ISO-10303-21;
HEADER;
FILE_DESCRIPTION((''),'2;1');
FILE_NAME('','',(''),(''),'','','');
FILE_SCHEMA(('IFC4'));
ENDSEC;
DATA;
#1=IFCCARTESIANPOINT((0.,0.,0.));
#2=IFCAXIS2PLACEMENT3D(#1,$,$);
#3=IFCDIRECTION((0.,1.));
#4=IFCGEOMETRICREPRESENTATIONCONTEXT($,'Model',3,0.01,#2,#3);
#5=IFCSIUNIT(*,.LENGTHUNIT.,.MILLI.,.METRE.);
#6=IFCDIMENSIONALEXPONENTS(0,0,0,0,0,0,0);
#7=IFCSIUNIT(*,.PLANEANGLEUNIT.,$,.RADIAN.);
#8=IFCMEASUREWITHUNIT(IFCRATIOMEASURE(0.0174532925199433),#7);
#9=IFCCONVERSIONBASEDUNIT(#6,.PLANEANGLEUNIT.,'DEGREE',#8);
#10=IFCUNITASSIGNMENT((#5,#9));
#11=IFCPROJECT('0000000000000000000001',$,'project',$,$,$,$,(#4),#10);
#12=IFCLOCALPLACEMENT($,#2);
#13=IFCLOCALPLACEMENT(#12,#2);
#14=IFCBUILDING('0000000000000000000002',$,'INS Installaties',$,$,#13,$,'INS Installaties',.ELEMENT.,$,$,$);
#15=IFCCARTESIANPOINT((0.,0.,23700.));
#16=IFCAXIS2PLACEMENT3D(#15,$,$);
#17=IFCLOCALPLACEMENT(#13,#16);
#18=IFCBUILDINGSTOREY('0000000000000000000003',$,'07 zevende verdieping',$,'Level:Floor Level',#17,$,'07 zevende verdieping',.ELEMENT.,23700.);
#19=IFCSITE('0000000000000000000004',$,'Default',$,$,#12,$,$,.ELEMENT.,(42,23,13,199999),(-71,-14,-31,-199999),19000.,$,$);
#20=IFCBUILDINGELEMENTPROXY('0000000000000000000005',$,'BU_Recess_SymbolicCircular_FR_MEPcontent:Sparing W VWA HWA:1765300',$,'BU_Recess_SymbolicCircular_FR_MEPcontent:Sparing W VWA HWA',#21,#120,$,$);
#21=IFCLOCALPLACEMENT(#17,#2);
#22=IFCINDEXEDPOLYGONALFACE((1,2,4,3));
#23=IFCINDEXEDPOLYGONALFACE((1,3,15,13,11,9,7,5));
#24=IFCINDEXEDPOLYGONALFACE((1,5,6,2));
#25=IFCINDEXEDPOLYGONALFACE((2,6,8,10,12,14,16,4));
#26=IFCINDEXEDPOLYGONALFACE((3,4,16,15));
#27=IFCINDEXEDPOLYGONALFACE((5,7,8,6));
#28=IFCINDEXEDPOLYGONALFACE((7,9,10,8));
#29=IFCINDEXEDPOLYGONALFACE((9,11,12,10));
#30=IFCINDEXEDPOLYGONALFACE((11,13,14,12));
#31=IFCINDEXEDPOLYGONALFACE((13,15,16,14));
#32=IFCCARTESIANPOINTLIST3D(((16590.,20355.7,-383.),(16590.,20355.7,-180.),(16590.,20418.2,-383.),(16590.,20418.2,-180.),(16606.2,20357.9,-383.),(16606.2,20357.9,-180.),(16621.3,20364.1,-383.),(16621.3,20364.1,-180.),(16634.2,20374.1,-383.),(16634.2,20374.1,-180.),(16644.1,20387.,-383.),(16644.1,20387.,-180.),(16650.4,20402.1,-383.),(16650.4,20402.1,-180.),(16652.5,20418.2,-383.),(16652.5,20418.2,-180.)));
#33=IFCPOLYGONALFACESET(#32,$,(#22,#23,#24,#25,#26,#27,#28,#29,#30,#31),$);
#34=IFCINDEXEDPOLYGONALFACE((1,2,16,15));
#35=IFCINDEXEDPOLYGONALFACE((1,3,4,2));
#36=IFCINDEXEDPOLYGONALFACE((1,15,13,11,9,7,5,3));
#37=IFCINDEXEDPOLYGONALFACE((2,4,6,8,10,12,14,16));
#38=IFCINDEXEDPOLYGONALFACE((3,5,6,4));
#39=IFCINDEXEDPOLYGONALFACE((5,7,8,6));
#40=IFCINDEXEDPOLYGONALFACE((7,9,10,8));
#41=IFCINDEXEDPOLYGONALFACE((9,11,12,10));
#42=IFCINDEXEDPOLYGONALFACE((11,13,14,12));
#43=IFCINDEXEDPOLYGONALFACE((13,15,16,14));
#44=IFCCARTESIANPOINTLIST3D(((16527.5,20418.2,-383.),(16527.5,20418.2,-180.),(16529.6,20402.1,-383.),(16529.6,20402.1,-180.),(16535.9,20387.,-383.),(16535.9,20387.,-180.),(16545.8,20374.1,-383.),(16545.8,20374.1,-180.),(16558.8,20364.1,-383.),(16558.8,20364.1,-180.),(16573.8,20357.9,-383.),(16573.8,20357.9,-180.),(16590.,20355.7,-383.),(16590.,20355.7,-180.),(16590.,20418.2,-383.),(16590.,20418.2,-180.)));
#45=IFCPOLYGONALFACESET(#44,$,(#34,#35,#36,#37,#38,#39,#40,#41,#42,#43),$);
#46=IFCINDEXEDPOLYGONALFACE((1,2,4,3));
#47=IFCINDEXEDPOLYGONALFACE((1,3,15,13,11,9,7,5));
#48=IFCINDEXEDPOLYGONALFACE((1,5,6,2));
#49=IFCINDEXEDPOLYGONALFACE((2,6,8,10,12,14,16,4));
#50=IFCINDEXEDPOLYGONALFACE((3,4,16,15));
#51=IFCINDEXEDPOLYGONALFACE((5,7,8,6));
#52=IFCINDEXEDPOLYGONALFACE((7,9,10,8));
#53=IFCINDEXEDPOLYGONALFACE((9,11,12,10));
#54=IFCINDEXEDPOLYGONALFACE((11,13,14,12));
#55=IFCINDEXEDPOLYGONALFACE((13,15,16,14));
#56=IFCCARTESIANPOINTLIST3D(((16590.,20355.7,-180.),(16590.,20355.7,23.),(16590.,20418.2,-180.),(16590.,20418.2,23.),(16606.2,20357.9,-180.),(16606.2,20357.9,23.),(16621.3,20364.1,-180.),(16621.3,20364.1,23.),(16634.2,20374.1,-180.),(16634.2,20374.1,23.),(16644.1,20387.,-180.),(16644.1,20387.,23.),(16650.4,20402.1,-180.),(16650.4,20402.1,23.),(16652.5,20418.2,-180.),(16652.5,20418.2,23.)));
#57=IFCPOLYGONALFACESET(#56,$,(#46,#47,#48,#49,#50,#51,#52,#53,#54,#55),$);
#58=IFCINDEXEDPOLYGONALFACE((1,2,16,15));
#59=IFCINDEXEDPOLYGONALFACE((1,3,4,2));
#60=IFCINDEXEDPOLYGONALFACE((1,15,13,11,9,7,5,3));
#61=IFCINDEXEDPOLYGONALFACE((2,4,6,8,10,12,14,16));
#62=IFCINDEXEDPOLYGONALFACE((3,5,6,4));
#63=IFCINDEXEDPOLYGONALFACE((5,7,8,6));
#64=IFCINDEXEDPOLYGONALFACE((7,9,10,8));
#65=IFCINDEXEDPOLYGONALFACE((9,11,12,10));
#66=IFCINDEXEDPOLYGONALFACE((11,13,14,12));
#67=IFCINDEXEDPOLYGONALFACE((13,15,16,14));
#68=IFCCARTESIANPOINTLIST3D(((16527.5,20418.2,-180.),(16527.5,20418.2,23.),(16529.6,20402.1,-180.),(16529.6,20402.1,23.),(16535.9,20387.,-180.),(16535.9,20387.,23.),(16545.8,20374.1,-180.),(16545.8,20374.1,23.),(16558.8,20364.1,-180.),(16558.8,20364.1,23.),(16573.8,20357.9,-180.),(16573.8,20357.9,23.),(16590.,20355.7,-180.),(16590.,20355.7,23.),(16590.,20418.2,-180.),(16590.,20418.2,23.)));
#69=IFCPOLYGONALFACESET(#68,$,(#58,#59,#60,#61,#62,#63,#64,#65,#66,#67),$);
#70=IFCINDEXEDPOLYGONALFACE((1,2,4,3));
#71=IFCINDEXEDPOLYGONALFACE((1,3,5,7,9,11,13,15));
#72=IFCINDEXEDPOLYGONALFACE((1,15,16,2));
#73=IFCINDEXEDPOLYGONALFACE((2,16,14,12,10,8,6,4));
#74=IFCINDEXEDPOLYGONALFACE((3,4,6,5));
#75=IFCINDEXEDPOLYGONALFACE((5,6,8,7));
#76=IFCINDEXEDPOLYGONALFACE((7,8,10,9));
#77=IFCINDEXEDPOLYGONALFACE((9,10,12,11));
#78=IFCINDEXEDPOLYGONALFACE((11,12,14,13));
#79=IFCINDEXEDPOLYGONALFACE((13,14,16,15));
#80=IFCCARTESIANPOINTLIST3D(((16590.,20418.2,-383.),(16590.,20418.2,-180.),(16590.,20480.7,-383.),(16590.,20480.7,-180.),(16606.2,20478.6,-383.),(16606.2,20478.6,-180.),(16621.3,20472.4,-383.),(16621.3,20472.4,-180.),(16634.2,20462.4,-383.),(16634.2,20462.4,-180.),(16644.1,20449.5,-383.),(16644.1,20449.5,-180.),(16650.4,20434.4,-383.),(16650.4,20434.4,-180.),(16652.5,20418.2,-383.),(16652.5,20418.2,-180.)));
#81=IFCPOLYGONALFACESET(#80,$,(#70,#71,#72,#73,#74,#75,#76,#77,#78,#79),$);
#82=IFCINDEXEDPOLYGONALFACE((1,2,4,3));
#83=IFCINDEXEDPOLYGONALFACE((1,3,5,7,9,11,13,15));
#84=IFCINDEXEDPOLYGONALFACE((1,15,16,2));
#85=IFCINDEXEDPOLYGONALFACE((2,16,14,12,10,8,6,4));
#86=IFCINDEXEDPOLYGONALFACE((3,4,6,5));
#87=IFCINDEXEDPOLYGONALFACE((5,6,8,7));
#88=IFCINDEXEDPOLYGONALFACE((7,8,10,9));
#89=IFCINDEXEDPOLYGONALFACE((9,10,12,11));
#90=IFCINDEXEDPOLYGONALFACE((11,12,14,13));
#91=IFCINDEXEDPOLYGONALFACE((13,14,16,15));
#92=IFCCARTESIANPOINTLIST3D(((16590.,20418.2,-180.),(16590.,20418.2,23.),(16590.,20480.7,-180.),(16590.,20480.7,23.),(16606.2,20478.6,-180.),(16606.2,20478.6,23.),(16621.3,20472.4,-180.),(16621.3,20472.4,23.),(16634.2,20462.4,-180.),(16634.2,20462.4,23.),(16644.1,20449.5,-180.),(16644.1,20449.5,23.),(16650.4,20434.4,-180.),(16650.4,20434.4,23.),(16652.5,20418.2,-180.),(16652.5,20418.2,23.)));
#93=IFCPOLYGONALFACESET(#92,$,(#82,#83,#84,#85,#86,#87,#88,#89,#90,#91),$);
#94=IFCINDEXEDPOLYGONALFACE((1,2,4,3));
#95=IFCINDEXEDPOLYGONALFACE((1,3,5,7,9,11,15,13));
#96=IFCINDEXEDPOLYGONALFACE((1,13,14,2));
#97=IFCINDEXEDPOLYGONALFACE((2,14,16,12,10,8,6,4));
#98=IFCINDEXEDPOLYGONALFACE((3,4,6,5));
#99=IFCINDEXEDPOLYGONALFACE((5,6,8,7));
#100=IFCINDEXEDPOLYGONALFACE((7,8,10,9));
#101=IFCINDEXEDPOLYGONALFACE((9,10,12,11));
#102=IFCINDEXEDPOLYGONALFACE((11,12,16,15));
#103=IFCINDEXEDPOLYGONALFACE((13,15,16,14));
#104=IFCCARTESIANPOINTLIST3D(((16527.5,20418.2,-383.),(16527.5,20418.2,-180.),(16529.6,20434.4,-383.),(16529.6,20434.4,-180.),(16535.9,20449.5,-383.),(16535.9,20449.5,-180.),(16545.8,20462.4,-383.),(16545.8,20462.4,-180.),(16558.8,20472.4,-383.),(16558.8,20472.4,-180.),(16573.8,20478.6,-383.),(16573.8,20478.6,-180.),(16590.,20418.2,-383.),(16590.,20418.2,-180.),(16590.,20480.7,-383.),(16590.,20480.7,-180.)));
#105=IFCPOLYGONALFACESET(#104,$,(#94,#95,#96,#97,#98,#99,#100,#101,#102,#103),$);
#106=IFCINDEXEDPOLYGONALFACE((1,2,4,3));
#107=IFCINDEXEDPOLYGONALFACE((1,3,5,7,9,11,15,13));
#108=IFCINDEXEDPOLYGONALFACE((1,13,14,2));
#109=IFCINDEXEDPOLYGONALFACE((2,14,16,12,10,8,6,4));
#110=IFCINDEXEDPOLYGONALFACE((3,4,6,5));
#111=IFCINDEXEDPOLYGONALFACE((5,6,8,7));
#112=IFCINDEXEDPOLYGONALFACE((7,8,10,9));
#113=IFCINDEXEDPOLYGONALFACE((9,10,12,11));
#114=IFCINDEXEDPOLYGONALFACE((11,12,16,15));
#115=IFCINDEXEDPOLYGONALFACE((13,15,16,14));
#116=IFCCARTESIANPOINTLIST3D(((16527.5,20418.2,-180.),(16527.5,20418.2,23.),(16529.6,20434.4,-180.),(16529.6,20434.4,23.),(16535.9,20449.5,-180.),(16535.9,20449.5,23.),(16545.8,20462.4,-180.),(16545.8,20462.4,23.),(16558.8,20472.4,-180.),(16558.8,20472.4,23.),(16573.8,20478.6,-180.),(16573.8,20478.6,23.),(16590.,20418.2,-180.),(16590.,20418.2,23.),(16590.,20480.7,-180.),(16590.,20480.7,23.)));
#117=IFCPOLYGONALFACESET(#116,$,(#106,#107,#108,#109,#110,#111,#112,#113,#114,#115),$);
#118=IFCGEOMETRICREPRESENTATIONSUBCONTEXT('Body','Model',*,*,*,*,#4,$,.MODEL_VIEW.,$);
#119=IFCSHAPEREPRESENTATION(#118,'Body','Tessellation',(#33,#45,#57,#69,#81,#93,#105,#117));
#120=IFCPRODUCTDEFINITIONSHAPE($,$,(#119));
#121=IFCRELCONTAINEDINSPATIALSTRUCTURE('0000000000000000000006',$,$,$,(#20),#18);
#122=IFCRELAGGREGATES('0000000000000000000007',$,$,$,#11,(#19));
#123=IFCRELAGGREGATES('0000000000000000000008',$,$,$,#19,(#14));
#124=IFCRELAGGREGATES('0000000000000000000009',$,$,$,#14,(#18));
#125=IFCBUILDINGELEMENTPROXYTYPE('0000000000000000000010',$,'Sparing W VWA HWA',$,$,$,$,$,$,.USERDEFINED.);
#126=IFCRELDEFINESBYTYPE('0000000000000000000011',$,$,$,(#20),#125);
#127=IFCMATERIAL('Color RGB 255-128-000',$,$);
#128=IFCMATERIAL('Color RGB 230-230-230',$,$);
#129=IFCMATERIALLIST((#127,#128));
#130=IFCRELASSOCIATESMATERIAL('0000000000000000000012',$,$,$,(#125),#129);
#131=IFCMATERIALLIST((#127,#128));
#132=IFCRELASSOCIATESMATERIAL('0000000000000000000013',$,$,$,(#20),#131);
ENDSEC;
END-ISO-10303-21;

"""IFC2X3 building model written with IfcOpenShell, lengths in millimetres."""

from ifc_helpers import new_model, entity, si_unit, converted_unit, direction, frame, frame_2d, origin, place, context, subcontext, project, spatial, polyline, circle_curve, parameter, trimmed, segment, composite_curve, outline, extrude, source, transform, mapped, material, material_list, type_object, type_shapes, element, save


model = new_model("IFC2X3")

# Units and contexts
model_context = context("Model", 3, precision=0.01, world=origin(), true_north=direction((0.0, 1.0)))
body_context = subcontext(model_context, "Body", "Model", "MODEL_VIEW")
ifc_project = project(units=[si_unit("LENGTHUNIT", "METRE", prefix="MILLI"), converted_unit("PLANEANGLEUNIT", "DEGREE", entity("IfcRatioMeasure", 0.0174532925199433), si_unit("PLANEANGLEUNIT", "RADIAN"), dimensions=[0, 0, 0, 0, 0, 0, 0])], contexts=[model_context])

# Site, building, storey
site_placement = place(None, origin())
site = spatial("IfcSite", under=ifc_project, at=site_placement, Name="Default", CompositionType="ELEMENT", RefLatitude=(42, 23, 13, 199999), RefLongitude=(-71, -14, -31, -199999), RefElevation=19000.0)
building_placement = place(site_placement, origin())
building = spatial("IfcBuilding", under=site, at=building_placement, Name="INS Installaties", LongName="INS Installaties", CompositionType="ELEMENT")
storey_placement = place(building_placement, frame((0.0, 0.0, 23700.0)))
storey = spatial("IfcBuildingStorey", under=building, at=storey_placement, Name="07 zevende verdieping", ObjectType="Level:Floor Level", LongName="07 zevende verdieping", CompositionType="ELEMENT", Elevation=23700.0)

# Building element proxy
ifc_material_1 = material(Name="Color RGB 255-128-000")
ifc_material_2 = material(Name="Color RGB 230-230-230")
ifc_material_list_1 = material_list([ifc_material_1, ifc_material_2])
building_element_proxy_type_1 = type_object("IfcBuildingElementProxyType", Name="Sparing W VWA HWA", PredefinedType="USERDEFINED", material=ifc_material_list_1)
shared_shape_1 = source(origin(), body_context, "Body", "SweptSolid", [
    extrude(outline(composite_curve([segment(polyline([(-41.7, -20.8), (20.8, -20.8)]), True, "CONTINUOUS"), segment(polyline([(20.8, -20.8), (20.8, 41.7)]), True, "CONTINUOUS"), segment(trimmed(circle_curve(frame_2d((20.8, -20.8), x_axis=(1.0, 0.0)), 62.5), [parameter(90.0)], [parameter(180.0)], True, "PARAMETER"), True, "CONTINUOUS")], self_intersect=False)), frame((20.8, -20.8, -403.0), z_axis=(0.0, 0.0, 1.0), x_axis=(-1.0, 0.0, 0.0)), (0.0, 0.0, 1.0), 203.0),
    extrude(outline(composite_curve([segment(trimmed(circle_curve(frame_2d((20.8, 20.8), x_axis=(1.0, 0.0)), 62.5), [parameter(180.0)], [parameter(270.0)], True, "PARAMETER"), True, "CONTINUOUS"), segment(polyline([(20.8, -41.7), (20.8, 20.8)]), True, "CONTINUOUS"), segment(polyline([(20.8, 20.8), (-41.7, 20.8)]), True, "CONTINUOUS")], self_intersect=False)), frame((-20.8, -20.8, -403.0)), (0.0, 0.0, 1.0), 203.0),
    extrude(outline(composite_curve([segment(polyline([(-41.7, -20.8), (20.8, -20.8)]), True, "CONTINUOUS"), segment(polyline([(20.8, -20.8), (20.8, 41.7)]), True, "CONTINUOUS"), segment(trimmed(circle_curve(frame_2d((20.8, -20.8), x_axis=(1.0, 0.0)), 62.5), [parameter(90.0)], [parameter(180.0)], True, "PARAMETER"), True, "CONTINUOUS")], self_intersect=False)), frame((20.8, -20.8, -200.0), z_axis=(0.0, 0.0, 1.0), x_axis=(-1.0, 0.0, 0.0)), (0.0, 0.0, 1.0), 203.0),
    extrude(outline(composite_curve([segment(trimmed(circle_curve(frame_2d((20.8, 20.8), x_axis=(1.0, 0.0)), 62.5), [parameter(180.0)], [parameter(270.0)], True, "PARAMETER"), True, "CONTINUOUS"), segment(polyline([(20.8, -41.7), (20.8, 20.8)]), True, "CONTINUOUS"), segment(polyline([(20.8, 20.8), (-41.7, 20.8)]), True, "CONTINUOUS")], self_intersect=False)), frame((-20.8, -20.8, -200.0)), (0.0, 0.0, 1.0), 203.0),
    extrude(outline(composite_curve([segment(trimmed(circle_curve(frame_2d((20.8, 20.8), x_axis=(1.0, 0.0)), 62.5), [parameter(180.0)], [parameter(270.0)], True, "PARAMETER"), True, "CONTINUOUS"), segment(polyline([(20.8, -41.7), (20.8, 20.8)]), True, "CONTINUOUS"), segment(polyline([(20.8, 20.8), (-41.7, 20.8)]), True, "CONTINUOUS")], self_intersect=False)), frame((20.8, 20.8, -403.0), z_axis=(0.0, 0.0, 1.0), x_axis=(-1.0, 0.0, 0.0)), (0.0, 0.0, 1.0), 203.0),
    extrude(outline(composite_curve([segment(trimmed(circle_curve(frame_2d((20.8, 20.8), x_axis=(1.0, 0.0)), 62.5), [parameter(180.0)], [parameter(270.0)], True, "PARAMETER"), True, "CONTINUOUS"), segment(polyline([(20.8, -41.7), (20.8, 20.8)]), True, "CONTINUOUS"), segment(polyline([(20.8, 20.8), (-41.7, 20.8)]), True, "CONTINUOUS")], self_intersect=False)), frame((20.8, 20.8, -200.0), z_axis=(0.0, 0.0, 1.0), x_axis=(-1.0, 0.0, 0.0)), (0.0, 0.0, 1.0), 203.0),
    extrude(outline(composite_curve([segment(polyline([(-41.7, -20.8), (20.8, -20.8)]), True, "CONTINUOUS"), segment(polyline([(20.8, -20.8), (20.8, 41.7)]), True, "CONTINUOUS"), segment(trimmed(circle_curve(frame_2d((20.8, -20.8), x_axis=(1.0, 0.0)), 62.5), [parameter(90.0)], [parameter(180.0)], True, "PARAMETER"), True, "CONTINUOUS")], self_intersect=False)), frame((-20.8, 20.8, -403.0)), (0.0, 0.0, 1.0), 203.0),
    extrude(outline(composite_curve([segment(polyline([(-41.7, -20.8), (20.8, -20.8)]), True, "CONTINUOUS"), segment(polyline([(20.8, -20.8), (20.8, 41.7)]), True, "CONTINUOUS"), segment(trimmed(circle_curve(frame_2d((20.8, -20.8), x_axis=(1.0, 0.0)), 62.5), [parameter(90.0)], [parameter(180.0)], True, "PARAMETER"), True, "CONTINUOUS")], self_intersect=False)), frame((-20.8, 20.8, -200.0)), (0.0, 0.0, 1.0), 203.0),
])
type_shapes(building_element_proxy_type_1, [shared_shape_1])
ifc_material_list_2 = material_list([ifc_material_1, ifc_material_2])
proxy_1_placement = place(storey_placement, frame((16590.0, 20418.2, 20.0)))
element("IfcBuildingElementProxy", 1, at=proxy_1_placement, inside=storey, type_object=building_element_proxy_type_1, material=ifc_material_list_2, Name="BU_Recess_SymbolicCircular_FR_MEPcontent:Sparing W VWA HWA:1765300", ObjectType="BU_Recess_SymbolicCircular_FR_MEPcontent:Sparing W VWA HWA", context=body_context, shape_type="MappedRepresentation", body=[
    mapped(shared_shape_1, transform((0.0, 0.0, 0.0), scale=1.0)),
])

save(model, "model.ifc")
